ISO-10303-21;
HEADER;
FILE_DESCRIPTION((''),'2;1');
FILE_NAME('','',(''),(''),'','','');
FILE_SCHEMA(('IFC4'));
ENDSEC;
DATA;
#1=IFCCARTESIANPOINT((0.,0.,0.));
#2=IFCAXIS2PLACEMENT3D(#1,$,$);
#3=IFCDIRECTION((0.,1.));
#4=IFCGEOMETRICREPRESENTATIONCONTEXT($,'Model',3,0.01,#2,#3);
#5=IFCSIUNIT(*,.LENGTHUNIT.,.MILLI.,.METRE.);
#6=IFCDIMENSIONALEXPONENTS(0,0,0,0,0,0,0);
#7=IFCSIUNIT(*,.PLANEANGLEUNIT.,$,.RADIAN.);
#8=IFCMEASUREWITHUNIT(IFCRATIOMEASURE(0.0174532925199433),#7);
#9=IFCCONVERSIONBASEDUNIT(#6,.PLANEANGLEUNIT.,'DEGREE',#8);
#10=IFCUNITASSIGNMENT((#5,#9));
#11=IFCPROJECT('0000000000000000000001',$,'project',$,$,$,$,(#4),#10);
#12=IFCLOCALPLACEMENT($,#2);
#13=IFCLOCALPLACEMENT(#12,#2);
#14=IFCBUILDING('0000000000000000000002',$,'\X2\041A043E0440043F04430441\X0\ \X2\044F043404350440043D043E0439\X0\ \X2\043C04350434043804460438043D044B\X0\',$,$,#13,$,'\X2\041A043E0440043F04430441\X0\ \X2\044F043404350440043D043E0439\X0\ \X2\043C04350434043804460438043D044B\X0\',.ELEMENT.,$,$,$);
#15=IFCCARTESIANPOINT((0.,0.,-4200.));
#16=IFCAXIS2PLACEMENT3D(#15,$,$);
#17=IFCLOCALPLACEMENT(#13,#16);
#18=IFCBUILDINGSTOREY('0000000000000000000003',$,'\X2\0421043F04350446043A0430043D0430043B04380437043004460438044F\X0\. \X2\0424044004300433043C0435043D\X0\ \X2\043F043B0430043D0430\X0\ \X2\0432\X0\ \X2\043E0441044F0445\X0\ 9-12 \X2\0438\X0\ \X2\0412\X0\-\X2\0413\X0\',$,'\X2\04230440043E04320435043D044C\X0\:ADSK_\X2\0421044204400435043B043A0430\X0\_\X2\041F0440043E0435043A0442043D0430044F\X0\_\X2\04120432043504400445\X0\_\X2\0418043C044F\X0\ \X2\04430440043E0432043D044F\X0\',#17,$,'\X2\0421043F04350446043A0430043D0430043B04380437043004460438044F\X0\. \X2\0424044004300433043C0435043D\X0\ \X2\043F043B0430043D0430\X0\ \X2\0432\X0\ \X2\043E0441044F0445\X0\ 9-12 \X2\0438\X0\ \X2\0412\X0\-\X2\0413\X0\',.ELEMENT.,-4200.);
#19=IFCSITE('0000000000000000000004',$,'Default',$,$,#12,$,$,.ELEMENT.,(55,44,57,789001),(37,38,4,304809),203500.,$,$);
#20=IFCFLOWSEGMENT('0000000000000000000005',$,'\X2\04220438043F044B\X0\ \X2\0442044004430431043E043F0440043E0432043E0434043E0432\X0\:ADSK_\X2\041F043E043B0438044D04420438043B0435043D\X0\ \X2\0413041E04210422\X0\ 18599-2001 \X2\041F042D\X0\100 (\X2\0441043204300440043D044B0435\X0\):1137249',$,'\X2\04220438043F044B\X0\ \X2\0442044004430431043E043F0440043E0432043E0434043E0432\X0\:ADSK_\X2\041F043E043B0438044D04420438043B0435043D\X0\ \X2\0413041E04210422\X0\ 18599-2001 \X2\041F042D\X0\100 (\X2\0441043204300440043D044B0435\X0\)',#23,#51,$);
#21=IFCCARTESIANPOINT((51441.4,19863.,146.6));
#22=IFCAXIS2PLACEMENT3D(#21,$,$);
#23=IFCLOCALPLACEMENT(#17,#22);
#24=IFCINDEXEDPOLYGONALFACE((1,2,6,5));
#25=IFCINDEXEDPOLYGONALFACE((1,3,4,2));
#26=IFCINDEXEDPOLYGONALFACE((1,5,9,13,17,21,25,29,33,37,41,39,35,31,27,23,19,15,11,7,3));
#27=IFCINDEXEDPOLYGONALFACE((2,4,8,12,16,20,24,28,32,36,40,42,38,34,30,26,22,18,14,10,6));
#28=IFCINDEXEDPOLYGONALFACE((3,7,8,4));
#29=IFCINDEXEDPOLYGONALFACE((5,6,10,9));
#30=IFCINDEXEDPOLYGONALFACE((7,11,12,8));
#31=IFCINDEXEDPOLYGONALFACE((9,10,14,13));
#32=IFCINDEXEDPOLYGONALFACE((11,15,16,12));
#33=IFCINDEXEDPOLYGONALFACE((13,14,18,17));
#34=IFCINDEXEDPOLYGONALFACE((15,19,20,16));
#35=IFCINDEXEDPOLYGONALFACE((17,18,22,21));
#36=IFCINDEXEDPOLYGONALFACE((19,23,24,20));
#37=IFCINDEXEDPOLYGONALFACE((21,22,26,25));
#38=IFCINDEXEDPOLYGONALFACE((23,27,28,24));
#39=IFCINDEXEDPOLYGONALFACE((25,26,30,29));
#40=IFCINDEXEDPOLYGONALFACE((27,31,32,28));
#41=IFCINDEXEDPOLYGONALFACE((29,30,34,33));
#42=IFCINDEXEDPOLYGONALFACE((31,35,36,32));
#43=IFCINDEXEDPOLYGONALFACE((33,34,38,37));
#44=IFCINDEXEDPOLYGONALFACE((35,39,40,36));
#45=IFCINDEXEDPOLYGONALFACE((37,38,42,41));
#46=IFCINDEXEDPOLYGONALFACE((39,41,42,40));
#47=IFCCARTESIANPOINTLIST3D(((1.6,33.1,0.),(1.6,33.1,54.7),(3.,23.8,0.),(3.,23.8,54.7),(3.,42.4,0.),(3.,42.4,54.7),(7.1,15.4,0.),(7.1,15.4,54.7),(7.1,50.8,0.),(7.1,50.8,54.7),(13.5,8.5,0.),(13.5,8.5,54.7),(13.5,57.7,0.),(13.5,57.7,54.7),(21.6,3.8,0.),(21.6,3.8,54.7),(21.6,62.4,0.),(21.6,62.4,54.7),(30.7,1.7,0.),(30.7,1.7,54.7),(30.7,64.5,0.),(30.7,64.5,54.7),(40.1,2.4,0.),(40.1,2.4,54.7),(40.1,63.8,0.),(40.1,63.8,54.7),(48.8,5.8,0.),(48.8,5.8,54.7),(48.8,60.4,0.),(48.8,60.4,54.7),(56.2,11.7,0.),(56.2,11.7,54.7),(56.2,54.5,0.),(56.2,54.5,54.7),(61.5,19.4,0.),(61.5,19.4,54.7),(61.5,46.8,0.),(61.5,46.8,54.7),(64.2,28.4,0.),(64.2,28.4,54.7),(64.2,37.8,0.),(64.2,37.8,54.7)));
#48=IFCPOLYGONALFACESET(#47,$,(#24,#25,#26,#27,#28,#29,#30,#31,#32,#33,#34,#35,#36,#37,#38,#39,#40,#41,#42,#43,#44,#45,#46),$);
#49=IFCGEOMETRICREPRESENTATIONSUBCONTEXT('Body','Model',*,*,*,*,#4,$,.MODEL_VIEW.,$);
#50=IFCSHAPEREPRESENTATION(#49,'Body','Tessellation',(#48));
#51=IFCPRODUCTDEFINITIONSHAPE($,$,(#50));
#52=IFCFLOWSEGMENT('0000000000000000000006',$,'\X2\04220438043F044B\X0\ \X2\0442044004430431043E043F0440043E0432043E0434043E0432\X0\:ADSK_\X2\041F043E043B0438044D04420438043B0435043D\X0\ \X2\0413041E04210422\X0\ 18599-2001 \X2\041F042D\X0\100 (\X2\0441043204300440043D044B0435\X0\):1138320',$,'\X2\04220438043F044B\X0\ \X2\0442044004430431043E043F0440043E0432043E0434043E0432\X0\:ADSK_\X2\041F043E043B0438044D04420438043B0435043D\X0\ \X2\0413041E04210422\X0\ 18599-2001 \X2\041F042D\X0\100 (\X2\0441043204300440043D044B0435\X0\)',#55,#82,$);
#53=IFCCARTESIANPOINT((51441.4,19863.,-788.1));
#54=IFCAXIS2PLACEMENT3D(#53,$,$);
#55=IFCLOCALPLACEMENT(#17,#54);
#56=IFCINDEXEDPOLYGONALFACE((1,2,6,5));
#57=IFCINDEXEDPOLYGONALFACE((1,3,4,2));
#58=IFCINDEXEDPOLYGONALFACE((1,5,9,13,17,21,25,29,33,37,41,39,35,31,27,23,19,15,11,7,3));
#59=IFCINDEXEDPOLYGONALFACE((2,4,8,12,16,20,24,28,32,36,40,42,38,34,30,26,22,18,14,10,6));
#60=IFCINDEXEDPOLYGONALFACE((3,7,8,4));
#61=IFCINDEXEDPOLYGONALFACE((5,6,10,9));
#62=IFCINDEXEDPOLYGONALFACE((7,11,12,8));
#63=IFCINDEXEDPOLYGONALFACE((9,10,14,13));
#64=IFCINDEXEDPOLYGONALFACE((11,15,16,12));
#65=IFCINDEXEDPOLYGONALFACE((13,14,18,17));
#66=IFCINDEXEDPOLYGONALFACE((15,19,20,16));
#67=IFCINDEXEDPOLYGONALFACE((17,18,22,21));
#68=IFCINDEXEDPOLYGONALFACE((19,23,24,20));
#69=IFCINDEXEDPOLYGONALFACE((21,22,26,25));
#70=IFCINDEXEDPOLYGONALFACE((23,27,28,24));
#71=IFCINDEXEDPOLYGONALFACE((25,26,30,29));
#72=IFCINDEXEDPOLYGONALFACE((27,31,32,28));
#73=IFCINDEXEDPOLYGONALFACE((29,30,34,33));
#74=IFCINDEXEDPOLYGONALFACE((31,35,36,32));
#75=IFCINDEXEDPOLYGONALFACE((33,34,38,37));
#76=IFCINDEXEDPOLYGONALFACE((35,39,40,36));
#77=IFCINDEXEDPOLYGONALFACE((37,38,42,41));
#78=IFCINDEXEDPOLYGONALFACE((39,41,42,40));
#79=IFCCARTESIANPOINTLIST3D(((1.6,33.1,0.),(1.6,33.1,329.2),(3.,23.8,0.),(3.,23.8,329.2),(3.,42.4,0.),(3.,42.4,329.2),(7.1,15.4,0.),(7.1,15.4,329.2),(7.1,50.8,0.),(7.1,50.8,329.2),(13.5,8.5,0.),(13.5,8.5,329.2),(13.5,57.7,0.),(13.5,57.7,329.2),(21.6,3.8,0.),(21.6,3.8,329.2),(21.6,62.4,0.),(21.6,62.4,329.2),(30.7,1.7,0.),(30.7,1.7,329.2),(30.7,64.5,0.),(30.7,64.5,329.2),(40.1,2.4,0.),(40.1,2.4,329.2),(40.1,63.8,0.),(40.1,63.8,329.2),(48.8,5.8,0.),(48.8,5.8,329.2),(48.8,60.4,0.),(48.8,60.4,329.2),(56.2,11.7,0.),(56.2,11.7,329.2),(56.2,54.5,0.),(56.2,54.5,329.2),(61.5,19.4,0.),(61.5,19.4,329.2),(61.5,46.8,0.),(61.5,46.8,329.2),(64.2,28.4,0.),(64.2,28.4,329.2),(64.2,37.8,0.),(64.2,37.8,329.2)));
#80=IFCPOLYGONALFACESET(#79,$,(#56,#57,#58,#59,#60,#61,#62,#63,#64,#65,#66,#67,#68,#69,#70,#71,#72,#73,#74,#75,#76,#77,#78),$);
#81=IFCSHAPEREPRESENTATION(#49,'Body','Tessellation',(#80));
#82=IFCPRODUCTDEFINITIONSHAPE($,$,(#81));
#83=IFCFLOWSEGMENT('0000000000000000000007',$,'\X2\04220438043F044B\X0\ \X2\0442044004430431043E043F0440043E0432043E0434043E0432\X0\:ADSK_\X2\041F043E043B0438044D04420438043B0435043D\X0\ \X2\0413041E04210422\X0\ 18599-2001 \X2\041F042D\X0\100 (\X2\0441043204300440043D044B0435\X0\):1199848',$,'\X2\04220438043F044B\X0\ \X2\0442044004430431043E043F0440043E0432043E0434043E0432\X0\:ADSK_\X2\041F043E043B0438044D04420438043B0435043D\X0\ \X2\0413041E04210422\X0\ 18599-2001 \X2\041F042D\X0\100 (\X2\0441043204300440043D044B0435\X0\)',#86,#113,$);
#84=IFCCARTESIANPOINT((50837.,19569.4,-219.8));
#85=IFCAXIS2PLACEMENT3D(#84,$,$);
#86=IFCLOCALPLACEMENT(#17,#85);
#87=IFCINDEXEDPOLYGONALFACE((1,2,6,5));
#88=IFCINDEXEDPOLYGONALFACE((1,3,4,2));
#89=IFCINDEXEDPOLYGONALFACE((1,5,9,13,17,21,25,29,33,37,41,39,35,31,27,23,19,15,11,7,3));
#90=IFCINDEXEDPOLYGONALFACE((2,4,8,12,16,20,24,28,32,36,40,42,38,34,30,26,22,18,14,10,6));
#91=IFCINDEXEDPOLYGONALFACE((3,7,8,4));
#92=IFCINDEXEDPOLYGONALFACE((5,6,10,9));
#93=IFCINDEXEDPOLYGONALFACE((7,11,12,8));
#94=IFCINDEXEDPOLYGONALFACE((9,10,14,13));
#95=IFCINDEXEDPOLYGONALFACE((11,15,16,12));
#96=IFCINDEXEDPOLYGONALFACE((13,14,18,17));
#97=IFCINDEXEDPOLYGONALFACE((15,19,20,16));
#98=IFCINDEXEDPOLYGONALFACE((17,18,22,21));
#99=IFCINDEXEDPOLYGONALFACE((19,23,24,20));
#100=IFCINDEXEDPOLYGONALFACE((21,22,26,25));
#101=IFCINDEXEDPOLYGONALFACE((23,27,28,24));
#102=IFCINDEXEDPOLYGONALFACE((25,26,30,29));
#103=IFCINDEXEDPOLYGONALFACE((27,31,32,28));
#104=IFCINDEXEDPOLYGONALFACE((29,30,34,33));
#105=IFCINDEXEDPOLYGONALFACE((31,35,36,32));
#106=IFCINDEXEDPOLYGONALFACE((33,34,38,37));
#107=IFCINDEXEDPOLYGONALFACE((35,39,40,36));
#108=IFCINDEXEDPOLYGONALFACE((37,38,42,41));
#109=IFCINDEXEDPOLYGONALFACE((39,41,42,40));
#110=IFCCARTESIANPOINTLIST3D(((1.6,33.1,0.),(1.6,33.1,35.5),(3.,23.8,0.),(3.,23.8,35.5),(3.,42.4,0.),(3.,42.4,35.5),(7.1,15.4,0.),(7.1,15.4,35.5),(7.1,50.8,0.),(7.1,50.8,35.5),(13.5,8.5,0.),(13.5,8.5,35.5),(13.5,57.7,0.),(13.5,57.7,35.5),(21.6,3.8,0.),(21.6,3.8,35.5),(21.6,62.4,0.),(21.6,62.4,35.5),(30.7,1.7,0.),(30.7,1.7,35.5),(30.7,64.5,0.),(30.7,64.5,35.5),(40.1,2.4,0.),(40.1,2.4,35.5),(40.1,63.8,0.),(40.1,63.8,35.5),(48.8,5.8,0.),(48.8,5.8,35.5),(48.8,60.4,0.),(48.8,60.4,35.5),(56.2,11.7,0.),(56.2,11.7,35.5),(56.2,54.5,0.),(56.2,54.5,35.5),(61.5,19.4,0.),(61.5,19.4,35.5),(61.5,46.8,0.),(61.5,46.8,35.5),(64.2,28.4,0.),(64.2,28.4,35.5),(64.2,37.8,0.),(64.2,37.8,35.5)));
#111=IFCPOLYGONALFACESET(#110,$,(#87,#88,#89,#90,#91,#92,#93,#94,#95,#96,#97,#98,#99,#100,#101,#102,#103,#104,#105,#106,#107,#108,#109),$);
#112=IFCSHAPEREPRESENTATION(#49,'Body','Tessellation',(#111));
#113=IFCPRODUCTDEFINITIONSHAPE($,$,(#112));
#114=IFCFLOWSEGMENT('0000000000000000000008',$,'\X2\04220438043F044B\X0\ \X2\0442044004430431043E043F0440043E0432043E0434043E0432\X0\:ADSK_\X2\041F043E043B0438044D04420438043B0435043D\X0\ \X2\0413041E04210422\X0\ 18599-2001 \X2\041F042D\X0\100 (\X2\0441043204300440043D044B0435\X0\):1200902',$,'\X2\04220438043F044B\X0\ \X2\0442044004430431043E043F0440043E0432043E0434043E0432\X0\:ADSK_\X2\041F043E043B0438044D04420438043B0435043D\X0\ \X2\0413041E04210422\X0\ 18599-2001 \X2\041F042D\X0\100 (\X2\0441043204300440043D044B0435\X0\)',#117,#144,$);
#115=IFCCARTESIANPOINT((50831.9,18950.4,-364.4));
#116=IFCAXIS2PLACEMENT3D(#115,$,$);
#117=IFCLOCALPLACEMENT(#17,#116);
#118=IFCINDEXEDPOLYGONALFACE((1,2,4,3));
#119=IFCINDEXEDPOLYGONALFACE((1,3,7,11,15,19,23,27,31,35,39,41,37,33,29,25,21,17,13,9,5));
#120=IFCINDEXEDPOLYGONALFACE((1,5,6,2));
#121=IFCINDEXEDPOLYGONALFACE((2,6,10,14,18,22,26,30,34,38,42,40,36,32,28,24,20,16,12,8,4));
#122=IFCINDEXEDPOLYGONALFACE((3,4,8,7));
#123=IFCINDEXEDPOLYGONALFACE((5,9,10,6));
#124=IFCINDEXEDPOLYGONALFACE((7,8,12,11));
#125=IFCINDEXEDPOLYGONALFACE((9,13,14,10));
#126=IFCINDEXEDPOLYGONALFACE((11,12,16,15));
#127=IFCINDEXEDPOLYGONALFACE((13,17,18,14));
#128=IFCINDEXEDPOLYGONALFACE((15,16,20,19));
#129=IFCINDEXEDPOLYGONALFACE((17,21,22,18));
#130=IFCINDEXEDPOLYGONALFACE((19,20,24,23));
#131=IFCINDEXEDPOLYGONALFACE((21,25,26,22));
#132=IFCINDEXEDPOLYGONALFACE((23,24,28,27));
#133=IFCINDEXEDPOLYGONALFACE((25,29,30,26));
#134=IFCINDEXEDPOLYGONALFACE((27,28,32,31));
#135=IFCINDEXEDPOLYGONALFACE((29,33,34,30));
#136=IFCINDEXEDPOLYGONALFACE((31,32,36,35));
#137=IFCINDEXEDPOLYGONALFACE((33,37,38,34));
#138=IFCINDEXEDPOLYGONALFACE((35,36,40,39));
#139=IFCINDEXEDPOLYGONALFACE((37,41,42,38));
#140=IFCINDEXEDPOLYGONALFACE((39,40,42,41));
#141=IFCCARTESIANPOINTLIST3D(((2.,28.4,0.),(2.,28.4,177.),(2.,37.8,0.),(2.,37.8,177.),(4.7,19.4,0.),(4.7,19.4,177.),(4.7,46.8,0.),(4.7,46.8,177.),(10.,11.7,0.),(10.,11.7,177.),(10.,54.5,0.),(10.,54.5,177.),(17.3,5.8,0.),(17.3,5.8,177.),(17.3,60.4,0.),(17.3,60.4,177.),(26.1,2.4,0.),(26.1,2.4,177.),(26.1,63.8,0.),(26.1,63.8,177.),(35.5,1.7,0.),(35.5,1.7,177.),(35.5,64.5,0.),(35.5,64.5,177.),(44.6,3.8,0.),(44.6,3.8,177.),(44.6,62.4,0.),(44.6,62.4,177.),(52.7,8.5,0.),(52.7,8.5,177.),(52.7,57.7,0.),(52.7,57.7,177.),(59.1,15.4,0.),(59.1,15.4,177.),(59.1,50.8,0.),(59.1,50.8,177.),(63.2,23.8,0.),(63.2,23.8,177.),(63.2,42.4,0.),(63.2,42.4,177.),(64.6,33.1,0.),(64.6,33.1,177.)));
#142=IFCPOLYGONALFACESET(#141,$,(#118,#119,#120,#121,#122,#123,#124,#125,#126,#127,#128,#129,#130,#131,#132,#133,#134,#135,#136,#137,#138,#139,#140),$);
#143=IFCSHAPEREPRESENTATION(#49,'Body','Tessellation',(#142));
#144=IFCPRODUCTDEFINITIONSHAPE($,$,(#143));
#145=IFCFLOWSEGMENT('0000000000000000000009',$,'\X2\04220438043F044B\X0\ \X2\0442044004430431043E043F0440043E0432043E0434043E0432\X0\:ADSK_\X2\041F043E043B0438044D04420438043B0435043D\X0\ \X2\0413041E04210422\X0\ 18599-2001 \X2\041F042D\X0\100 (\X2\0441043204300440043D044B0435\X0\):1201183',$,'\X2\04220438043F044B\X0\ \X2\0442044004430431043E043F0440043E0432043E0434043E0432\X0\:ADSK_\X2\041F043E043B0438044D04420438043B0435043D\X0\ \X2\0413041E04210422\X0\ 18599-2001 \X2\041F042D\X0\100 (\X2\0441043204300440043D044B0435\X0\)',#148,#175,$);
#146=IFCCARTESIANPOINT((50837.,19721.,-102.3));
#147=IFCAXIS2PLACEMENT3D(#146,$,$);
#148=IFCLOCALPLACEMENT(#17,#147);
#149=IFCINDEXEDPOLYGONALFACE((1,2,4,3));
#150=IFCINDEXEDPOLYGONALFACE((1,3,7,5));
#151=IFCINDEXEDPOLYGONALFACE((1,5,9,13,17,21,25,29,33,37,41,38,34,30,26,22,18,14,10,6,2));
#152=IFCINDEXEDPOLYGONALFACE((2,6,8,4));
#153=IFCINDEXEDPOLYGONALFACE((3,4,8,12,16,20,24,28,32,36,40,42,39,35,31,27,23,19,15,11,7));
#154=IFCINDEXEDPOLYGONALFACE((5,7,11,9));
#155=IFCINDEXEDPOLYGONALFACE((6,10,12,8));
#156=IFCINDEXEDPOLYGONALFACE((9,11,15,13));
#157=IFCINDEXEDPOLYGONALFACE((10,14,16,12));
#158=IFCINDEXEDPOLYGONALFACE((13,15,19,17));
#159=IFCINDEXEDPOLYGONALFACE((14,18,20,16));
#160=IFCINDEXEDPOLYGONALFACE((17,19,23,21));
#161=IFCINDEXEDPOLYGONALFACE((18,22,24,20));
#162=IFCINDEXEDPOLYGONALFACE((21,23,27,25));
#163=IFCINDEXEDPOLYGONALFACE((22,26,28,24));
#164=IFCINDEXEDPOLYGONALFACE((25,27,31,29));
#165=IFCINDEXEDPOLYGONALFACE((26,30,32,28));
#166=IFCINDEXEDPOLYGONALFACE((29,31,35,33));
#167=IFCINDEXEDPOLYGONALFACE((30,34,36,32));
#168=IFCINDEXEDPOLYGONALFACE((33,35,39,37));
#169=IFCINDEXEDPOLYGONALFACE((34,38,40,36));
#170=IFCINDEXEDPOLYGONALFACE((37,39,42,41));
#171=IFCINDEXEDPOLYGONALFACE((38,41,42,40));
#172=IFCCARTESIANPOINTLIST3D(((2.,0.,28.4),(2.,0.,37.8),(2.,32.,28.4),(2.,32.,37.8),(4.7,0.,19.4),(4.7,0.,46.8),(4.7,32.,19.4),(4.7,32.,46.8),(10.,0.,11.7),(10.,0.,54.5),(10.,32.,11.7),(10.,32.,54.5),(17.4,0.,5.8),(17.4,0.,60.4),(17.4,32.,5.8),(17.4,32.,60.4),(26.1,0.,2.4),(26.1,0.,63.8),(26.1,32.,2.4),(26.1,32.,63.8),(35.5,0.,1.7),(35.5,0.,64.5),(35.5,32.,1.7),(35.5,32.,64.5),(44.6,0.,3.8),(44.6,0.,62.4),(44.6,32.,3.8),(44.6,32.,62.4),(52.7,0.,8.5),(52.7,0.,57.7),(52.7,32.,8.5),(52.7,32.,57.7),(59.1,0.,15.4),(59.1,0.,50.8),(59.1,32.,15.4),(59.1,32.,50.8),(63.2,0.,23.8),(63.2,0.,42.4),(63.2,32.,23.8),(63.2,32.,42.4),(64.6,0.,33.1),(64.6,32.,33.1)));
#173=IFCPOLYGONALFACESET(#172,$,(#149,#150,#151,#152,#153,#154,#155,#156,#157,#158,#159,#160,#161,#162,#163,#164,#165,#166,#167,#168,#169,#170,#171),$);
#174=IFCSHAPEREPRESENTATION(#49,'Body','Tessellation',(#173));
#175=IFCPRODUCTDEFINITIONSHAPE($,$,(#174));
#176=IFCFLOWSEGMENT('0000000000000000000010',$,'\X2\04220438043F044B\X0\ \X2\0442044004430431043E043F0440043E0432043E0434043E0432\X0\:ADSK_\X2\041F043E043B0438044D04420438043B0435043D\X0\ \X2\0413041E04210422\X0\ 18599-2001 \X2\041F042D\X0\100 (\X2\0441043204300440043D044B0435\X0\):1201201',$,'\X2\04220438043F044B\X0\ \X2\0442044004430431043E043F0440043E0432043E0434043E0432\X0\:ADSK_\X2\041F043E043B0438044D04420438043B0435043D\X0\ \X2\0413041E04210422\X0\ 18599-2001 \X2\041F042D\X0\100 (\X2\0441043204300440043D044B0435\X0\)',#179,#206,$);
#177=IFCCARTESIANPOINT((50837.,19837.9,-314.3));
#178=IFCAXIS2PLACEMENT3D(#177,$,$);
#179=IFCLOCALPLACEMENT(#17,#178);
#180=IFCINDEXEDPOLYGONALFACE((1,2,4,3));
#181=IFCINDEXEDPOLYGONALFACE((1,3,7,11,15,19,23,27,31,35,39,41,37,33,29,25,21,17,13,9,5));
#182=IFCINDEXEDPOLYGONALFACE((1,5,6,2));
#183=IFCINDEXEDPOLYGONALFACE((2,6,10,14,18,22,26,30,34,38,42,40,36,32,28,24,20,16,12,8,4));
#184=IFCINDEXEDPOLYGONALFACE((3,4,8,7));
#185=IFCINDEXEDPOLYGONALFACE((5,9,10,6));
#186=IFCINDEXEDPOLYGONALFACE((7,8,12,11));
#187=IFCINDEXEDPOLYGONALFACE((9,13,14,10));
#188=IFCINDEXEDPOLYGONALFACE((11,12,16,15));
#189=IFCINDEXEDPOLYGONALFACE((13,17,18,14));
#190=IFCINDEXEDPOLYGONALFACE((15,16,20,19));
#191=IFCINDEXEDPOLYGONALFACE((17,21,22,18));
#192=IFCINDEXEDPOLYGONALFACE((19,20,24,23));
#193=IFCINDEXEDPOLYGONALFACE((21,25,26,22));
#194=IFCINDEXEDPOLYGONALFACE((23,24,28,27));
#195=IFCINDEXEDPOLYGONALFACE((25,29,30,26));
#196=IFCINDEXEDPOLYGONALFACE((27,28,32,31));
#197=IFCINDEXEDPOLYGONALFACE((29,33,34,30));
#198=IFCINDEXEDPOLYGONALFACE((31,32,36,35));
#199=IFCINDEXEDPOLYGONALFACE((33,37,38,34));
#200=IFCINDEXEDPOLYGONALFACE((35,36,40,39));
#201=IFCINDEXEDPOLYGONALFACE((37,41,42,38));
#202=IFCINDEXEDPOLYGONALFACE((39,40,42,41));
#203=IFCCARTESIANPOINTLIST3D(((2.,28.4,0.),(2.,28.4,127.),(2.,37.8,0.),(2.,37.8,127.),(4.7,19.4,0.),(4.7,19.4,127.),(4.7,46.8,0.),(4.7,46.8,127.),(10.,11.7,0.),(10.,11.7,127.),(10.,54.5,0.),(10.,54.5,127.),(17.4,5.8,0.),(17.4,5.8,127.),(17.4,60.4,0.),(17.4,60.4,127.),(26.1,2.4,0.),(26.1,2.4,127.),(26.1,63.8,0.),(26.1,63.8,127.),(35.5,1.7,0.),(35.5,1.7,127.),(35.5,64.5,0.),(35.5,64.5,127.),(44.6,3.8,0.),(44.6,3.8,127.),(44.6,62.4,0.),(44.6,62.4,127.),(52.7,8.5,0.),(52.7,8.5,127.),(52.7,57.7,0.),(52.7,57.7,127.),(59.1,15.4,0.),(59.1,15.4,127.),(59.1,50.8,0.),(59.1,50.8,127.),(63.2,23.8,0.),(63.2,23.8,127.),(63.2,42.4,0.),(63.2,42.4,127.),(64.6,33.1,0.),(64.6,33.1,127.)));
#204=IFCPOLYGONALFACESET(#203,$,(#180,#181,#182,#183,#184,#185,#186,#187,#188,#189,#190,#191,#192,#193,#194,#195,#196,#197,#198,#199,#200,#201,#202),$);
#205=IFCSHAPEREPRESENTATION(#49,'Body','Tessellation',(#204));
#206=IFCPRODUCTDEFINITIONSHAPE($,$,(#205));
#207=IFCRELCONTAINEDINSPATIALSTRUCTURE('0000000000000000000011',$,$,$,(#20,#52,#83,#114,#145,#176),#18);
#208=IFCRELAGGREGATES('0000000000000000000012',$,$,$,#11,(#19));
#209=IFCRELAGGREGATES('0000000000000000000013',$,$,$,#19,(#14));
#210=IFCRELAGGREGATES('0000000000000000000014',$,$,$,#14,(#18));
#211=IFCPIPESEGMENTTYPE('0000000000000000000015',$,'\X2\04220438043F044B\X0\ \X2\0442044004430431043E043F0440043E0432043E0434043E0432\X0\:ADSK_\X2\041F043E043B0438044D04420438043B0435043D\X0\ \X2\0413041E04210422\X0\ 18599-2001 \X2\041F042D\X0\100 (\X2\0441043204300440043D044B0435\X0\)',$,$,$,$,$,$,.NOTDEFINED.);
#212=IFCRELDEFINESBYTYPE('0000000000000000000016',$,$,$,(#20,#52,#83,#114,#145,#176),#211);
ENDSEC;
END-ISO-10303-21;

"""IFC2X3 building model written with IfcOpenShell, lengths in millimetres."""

from ifc_helpers import new_model, entity, si_unit, converted_unit, direction, frame, origin, origin_2d_with_axis, place, context, subcontext, project, spatial, circle, extrude, type_object, element, save


model = new_model("IFC2X3")

# Units and contexts
model_context = context("Model", 3, precision=0.01, world=origin(), true_north=direction((0.0, 1.0)))
body_context = subcontext(model_context, "Body", "Model", "MODEL_VIEW")
ifc_project = project(units=[si_unit("LENGTHUNIT", "METRE", prefix="MILLI"), converted_unit("PLANEANGLEUNIT", "DEGREE", entity("IfcRatioMeasure", 0.0174532925199433), si_unit("PLANEANGLEUNIT", "RADIAN"), dimensions=[0, 0, 0, 0, 0, 0, 0])], contexts=[model_context])

# Site, building, storey
site_placement = place(None, origin())
site = spatial("IfcSite", under=ifc_project, at=site_placement, Name="Default", CompositionType="ELEMENT", RefLatitude=(55, 44, 57, 789001), RefLongitude=(37, 38, 4, 304809), RefElevation=203500.0)
building_placement = place(site_placement, origin())
building = spatial("IfcBuilding", under=site, at=building_placement, Name="Корпус ядерной медицины", LongName="Корпус ядерной медицины", CompositionType="ELEMENT")
storey_placement = place(building_placement, frame((0.0, 0.0, -4200.0)))
storey = spatial("IfcBuildingStorey", under=building, at=storey_placement, Name="Спецканализация. Фрагмен плана в осях 9-12 и В-Г", ObjectType="Уровень:ADSK_Стрелка_Проектная_Вверх_Имя уровня", LongName="Спецканализация. Фрагмен плана в осях 9-12 и В-Г", CompositionType="ELEMENT", Elevation=-4200.0)

# Flow segments
pipe_segment_type = type_object("IfcPipeSegmentType", Name="Типы трубопроводов:ADSK_Полиэтилен ГОСТ 18599-2001 ПЭ100 (сварные)", PredefinedType="NOTDEFINED")
flow_segment_1_placement = place(storey_placement, frame((51441.4, 19863.0, 146.6)))
element("IfcFlowSegment", 1, at=flow_segment_1_placement, inside=storey, type_object=pipe_segment_type, Name="Типы трубопроводов:ADSK_Полиэтилен ГОСТ 18599-2001 ПЭ100 (сварные):1137249", ObjectType="Типы трубопроводов:ADSK_Полиэтилен ГОСТ 18599-2001 ПЭ100 (сварные)", context=body_context, shape_type="SweptSolid", body=[
    extrude(circle(Radius=31.5, at=origin_2d_with_axis()), frame((33.1, 33.1, 0.0), z_axis=(0.0, 0.0, 1.0), x_axis=(-1.0, 0.0, 0.0)), (0.0, 0.0, 1.0), 54.7),
])
flow_segment_2_placement = place(storey_placement, frame((51441.4, 19863.0, -788.1)))
element("IfcFlowSegment", 2, at=flow_segment_2_placement, inside=storey, type_object=pipe_segment_type, Name="Типы трубопроводов:ADSK_Полиэтилен ГОСТ 18599-2001 ПЭ100 (сварные):1138320", ObjectType="Типы трубопроводов:ADSK_Полиэтилен ГОСТ 18599-2001 ПЭ100 (сварные)", context=body_context, shape_type="SweptSolid", body=[
    extrude(circle(Radius=31.5, at=origin_2d_with_axis()), frame((33.1, 33.1, 0.0), z_axis=(0.0, 0.0, 1.0), x_axis=(-1.0, 0.0, 0.0)), (0.0, 0.0, 1.0), 329.2),
])
flow_segment_3_placement = place(storey_placement, frame((50837.0, 19569.4, -219.8)))
element("IfcFlowSegment", 3, at=flow_segment_3_placement, inside=storey, type_object=pipe_segment_type, Name="Типы трубопроводов:ADSK_Полиэтилен ГОСТ 18599-2001 ПЭ100 (сварные):1199848", ObjectType="Типы трубопроводов:ADSK_Полиэтилен ГОСТ 18599-2001 ПЭ100 (сварные)", context=body_context, shape_type="SweptSolid", body=[
    extrude(circle(Radius=31.5, at=origin_2d_with_axis()), frame((33.1, 33.1, 0.0), z_axis=(0.0, 0.0, 1.0), x_axis=(-1.0, 0.0, 0.0)), (0.0, 0.0, 1.0), 35.5),
])
flow_segment_4_placement = place(storey_placement, frame((50831.9, 18950.4, -364.4)))
element("IfcFlowSegment", 4, at=flow_segment_4_placement, inside=storey, type_object=pipe_segment_type, Name="Типы трубопроводов:ADSK_Полиэтилен ГОСТ 18599-2001 ПЭ100 (сварные):1200902", ObjectType="Типы трубопроводов:ADSK_Полиэтилен ГОСТ 18599-2001 ПЭ100 (сварные)", context=body_context, shape_type="SweptSolid", body=[
    extrude(circle(Radius=31.5, at=origin_2d_with_axis()), frame((33.1, 33.1, 0.0)), (0.0, 0.0, 1.0), 177.0),
])
flow_segment_5_placement = place(storey_placement, frame((50837.0, 19721.0, -102.3)))
element("IfcFlowSegment", 5, at=flow_segment_5_placement, inside=storey, type_object=pipe_segment_type, Name="Типы трубопроводов:ADSK_Полиэтилен ГОСТ 18599-2001 ПЭ100 (сварные):1201183", ObjectType="Типы трубопроводов:ADSK_Полиэтилен ГОСТ 18599-2001 ПЭ100 (сварные)", context=body_context, shape_type="SweptSolid", body=[
    extrude(circle(Radius=31.5, at=origin_2d_with_axis()), frame((33.1, 0.0, 33.1), z_axis=(0.0, 1.0, 0.0), x_axis=(1.0, 0.0, 0.0)), (0.0, 0.0, 1.0), 32.0),
])
flow_segment_6_placement = place(storey_placement, frame((50837.0, 19837.9, -314.3)))
element("IfcFlowSegment", 6, at=flow_segment_6_placement, inside=storey, type_object=pipe_segment_type, Name="Типы трубопроводов:ADSK_Полиэтилен ГОСТ 18599-2001 ПЭ100 (сварные):1201201", ObjectType="Типы трубопроводов:ADSK_Полиэтилен ГОСТ 18599-2001 ПЭ100 (сварные)", context=body_context, shape_type="SweptSolid", body=[
    extrude(circle(Radius=31.5, at=origin_2d_with_axis()), frame((33.1, 33.1, 0.0)), (0.0, 0.0, 1.0), 127.0),
])

save(model, "model.ifc")
